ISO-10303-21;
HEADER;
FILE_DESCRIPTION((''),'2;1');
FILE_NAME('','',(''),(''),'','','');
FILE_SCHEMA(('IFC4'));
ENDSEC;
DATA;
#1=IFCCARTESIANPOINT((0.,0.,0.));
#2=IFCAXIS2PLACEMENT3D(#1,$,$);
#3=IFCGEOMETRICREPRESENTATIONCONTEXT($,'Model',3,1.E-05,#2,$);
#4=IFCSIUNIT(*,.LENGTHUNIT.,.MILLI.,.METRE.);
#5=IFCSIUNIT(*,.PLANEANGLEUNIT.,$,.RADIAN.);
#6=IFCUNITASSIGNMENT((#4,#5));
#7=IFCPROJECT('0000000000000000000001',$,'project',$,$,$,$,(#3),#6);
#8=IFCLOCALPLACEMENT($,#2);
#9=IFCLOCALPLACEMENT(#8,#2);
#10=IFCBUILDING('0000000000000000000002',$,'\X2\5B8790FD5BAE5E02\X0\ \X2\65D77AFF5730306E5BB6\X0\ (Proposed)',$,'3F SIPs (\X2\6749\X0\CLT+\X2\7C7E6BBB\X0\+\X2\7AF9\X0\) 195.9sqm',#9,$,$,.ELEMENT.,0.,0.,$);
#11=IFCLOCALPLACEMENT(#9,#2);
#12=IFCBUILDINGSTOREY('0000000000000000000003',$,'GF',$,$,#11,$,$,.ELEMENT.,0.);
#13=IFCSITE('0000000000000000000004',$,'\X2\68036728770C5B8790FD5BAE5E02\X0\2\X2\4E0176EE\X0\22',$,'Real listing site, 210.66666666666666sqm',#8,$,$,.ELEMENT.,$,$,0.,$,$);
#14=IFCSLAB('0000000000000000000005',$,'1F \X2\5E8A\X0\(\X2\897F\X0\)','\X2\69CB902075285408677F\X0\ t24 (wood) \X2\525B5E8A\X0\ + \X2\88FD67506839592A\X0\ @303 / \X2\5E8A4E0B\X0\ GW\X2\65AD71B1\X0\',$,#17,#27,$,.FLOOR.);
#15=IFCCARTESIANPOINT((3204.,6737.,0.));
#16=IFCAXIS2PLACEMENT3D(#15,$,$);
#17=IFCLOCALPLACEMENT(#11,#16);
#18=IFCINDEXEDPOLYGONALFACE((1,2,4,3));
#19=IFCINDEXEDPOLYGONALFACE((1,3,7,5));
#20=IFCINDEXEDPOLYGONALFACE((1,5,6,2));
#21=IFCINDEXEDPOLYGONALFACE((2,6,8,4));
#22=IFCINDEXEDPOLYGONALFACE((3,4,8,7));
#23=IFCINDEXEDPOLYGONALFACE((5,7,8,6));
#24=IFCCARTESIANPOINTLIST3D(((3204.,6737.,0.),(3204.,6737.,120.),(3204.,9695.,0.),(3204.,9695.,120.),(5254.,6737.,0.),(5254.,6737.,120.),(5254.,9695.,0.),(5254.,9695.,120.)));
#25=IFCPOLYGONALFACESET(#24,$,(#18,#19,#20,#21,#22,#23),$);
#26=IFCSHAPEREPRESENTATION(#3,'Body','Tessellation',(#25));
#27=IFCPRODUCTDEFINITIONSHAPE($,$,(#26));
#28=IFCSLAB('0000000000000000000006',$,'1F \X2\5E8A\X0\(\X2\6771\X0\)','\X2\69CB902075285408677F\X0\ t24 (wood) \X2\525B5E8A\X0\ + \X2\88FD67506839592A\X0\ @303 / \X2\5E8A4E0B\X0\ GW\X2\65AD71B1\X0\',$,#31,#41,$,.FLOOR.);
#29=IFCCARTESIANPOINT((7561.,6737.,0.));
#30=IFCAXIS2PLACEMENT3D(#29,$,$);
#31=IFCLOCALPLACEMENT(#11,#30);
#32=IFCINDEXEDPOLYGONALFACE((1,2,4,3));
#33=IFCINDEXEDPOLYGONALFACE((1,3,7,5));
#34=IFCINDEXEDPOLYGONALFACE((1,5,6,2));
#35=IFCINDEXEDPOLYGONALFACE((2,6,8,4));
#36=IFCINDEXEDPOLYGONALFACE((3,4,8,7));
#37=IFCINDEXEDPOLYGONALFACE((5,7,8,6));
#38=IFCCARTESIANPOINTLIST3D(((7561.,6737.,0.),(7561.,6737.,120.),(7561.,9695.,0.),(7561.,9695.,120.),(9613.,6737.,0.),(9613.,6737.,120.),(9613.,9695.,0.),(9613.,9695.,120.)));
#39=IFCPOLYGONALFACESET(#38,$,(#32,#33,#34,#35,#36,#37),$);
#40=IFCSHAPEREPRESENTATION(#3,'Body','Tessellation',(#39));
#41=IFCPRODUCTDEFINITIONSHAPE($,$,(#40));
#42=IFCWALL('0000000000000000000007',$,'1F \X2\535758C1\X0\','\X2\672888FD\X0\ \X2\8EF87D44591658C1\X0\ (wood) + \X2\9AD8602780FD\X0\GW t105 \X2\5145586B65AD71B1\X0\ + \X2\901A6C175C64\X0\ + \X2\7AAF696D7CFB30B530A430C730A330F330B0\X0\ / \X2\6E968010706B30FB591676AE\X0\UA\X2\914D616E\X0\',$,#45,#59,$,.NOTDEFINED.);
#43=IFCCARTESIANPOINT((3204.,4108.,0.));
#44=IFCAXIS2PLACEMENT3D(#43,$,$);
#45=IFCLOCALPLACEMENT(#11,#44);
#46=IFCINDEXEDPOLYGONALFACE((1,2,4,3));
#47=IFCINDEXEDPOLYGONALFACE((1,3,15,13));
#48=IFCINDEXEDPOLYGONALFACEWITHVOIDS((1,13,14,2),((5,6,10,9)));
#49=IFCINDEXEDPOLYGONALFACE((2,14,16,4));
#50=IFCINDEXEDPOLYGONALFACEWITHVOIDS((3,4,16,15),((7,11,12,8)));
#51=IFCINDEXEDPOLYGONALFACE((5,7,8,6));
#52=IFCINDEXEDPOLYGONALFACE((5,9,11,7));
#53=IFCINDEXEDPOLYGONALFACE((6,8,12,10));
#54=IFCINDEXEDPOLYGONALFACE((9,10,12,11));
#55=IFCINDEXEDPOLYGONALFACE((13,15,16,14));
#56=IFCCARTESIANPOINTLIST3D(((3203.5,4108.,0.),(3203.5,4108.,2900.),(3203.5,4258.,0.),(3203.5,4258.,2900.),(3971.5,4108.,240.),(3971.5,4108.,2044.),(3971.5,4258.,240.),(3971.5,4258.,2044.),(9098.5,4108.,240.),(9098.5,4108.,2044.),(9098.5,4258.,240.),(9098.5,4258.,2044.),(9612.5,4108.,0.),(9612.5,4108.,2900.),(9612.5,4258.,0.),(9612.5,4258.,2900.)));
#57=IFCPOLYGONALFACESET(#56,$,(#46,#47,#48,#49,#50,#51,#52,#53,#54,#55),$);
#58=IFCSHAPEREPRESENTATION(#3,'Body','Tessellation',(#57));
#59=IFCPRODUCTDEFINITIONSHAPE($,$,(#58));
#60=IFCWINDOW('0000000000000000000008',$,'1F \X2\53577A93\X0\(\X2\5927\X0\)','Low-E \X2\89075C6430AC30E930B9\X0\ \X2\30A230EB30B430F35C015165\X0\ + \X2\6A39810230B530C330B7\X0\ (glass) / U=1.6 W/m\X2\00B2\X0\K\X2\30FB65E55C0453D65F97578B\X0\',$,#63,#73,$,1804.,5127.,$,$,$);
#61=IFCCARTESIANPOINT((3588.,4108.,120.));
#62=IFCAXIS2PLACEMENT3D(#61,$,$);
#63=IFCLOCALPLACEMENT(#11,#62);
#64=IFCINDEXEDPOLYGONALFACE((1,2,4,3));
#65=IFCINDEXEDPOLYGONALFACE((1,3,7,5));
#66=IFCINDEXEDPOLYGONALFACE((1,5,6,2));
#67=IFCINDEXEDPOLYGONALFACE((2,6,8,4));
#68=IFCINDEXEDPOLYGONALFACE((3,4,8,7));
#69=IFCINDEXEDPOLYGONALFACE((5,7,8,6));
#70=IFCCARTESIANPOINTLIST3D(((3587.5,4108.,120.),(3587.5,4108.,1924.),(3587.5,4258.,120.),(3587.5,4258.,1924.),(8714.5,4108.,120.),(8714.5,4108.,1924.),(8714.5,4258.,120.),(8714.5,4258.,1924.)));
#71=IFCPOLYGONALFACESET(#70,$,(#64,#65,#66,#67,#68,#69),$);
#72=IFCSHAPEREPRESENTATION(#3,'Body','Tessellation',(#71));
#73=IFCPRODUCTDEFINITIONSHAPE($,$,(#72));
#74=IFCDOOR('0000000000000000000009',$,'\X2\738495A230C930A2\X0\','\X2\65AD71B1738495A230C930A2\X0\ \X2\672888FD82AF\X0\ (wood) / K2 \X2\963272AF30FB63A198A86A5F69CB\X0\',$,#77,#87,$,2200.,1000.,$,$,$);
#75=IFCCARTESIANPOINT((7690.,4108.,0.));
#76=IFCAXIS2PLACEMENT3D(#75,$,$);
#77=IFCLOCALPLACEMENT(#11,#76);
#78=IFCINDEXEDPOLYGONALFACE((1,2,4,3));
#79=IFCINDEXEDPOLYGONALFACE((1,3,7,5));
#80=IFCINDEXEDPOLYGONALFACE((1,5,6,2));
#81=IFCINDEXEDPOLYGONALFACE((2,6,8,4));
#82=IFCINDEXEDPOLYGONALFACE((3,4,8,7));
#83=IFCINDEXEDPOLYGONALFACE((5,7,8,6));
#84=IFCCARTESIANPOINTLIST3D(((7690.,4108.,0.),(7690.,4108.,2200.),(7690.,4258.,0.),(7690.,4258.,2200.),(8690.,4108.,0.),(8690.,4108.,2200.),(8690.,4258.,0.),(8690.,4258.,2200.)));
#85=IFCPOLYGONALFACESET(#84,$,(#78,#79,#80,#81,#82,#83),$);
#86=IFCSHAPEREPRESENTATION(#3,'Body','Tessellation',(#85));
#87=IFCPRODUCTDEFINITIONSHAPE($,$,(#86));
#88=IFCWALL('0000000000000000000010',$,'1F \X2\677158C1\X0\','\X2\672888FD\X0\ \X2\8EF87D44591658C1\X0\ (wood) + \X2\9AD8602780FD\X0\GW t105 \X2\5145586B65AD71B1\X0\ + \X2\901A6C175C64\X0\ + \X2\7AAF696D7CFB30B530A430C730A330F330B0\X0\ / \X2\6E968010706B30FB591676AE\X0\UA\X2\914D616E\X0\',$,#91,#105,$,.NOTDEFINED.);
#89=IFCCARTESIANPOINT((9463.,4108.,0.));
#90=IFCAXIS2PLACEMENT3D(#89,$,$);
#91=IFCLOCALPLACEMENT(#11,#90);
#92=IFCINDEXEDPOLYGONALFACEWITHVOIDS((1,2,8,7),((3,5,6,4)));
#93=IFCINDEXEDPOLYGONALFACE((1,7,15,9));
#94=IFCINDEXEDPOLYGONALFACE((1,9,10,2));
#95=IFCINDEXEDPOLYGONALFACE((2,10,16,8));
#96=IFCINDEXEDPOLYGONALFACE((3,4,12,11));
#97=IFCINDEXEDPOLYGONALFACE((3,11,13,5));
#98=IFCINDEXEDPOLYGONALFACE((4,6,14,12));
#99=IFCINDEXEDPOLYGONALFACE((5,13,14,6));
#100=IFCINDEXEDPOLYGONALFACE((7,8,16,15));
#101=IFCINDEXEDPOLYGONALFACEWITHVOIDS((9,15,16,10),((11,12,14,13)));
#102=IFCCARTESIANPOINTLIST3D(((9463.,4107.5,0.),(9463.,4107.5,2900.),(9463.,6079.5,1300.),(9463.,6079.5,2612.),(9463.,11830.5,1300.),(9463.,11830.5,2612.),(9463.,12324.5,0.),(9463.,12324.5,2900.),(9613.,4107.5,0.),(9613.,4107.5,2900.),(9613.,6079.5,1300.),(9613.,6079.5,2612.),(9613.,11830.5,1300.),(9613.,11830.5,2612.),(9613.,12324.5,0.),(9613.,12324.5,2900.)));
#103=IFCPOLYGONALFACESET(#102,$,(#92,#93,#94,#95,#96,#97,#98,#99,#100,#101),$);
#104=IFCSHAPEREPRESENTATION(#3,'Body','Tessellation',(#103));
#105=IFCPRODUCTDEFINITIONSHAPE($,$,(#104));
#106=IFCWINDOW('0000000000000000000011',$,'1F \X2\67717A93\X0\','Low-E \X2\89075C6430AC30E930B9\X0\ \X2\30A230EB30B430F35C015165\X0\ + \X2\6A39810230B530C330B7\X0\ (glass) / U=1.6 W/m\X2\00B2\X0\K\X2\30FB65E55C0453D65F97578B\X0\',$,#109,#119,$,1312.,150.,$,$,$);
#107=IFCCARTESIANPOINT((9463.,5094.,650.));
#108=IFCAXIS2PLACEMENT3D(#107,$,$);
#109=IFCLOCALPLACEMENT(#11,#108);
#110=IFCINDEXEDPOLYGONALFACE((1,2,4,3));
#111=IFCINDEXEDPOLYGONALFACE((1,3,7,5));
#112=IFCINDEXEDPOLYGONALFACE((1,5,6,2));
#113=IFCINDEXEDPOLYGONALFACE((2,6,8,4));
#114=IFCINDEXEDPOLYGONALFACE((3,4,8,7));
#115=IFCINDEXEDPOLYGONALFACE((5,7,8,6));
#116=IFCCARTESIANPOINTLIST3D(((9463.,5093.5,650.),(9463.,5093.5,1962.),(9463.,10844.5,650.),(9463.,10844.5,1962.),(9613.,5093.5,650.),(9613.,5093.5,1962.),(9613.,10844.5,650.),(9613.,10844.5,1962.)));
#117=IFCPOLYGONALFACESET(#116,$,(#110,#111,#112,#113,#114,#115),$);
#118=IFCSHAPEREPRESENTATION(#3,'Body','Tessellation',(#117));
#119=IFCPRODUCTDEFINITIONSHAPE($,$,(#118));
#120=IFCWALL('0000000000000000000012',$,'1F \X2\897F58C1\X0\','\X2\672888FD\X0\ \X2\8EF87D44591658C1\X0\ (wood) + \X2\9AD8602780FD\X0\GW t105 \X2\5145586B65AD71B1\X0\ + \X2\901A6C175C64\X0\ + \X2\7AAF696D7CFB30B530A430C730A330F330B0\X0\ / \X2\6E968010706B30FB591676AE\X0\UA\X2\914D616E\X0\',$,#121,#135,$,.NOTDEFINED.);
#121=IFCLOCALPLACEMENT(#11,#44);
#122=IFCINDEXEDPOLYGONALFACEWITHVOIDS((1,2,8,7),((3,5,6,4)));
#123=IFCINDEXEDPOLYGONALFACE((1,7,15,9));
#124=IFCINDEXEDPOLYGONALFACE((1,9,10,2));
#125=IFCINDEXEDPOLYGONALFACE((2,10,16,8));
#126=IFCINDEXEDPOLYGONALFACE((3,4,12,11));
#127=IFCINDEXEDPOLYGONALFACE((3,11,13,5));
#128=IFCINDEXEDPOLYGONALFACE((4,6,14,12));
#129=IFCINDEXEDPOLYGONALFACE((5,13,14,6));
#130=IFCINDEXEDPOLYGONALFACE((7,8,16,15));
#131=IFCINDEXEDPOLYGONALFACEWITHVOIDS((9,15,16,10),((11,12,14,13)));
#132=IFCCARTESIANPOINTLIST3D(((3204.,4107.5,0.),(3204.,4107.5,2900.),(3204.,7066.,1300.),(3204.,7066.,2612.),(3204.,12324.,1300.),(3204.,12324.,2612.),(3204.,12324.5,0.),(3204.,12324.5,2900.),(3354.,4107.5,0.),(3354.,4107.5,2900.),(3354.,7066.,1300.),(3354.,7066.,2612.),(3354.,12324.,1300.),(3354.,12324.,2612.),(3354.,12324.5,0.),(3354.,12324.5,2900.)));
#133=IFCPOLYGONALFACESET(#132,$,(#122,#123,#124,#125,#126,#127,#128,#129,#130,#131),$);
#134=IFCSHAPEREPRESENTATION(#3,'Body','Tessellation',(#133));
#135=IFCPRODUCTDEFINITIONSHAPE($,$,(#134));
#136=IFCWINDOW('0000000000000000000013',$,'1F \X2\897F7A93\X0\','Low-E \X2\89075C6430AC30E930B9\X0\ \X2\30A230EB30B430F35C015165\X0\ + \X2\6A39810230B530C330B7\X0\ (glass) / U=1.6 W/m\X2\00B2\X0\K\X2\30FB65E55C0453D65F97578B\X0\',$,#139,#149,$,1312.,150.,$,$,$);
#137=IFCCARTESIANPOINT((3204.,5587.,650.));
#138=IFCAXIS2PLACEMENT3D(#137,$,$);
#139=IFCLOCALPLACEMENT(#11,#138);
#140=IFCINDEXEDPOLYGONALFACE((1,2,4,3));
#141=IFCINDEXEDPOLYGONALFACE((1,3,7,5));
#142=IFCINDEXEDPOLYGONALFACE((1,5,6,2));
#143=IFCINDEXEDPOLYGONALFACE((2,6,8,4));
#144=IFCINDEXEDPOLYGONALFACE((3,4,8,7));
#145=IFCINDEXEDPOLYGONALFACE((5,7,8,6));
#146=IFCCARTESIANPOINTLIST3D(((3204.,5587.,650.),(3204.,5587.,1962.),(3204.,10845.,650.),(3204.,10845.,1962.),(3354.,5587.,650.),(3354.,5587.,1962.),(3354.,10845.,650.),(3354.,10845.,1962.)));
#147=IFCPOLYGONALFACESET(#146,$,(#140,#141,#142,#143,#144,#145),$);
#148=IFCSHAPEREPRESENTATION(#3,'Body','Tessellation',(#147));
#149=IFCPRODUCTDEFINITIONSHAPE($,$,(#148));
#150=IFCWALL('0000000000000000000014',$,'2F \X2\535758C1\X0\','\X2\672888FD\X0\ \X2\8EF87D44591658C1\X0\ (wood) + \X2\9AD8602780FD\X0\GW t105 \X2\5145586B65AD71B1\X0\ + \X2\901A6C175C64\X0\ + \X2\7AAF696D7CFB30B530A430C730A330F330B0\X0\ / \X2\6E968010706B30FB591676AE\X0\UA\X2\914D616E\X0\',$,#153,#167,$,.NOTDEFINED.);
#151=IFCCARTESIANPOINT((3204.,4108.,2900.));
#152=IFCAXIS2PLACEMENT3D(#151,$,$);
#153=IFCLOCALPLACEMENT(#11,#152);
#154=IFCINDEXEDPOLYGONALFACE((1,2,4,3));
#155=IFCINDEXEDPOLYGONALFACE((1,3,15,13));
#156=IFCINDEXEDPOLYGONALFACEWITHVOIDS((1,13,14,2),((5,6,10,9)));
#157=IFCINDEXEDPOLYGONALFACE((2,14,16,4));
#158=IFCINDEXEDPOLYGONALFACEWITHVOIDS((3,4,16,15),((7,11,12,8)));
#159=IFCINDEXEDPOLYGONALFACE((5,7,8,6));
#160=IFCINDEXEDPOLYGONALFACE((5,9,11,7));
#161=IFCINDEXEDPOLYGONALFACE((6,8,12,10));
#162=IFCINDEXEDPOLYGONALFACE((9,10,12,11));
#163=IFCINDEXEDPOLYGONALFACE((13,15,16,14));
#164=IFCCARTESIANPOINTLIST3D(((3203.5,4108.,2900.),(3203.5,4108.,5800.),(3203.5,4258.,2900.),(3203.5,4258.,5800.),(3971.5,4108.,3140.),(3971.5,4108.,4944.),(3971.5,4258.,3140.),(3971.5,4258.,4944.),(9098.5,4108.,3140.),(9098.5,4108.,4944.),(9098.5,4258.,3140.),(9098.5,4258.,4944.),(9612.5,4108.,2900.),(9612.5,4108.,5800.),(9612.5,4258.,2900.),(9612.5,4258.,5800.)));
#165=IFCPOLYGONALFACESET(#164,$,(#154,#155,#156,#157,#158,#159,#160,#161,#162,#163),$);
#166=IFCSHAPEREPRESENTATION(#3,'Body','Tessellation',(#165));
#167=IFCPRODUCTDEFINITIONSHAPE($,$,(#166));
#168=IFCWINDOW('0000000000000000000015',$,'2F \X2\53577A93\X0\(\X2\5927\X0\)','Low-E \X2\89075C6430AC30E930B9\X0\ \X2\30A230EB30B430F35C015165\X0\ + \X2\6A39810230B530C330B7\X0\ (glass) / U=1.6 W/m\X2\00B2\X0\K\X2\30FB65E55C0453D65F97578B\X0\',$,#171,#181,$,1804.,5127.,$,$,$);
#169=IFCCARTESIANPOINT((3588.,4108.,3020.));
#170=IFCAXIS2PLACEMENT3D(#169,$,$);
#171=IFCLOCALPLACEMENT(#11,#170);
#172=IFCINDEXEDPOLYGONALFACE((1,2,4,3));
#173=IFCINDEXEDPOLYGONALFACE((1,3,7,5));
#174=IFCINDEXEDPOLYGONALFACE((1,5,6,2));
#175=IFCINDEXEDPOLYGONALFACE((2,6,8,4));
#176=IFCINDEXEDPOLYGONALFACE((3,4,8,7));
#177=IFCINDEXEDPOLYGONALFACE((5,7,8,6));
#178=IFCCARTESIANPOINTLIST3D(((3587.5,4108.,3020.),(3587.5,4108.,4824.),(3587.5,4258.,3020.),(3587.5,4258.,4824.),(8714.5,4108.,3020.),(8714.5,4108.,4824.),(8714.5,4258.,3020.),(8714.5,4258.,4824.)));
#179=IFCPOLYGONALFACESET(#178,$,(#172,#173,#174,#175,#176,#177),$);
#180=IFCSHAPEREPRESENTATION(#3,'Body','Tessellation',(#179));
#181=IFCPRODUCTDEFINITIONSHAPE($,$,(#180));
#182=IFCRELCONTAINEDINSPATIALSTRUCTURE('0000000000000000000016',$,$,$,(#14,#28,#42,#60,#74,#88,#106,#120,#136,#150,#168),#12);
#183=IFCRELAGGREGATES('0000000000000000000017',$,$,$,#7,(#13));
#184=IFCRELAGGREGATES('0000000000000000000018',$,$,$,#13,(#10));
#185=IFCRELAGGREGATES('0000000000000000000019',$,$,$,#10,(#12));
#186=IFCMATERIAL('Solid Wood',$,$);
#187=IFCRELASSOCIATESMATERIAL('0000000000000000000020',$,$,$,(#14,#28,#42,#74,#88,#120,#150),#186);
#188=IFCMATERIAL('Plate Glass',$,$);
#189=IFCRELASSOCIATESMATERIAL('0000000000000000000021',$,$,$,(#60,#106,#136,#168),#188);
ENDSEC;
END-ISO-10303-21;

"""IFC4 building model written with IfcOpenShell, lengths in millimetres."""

from ifc_helpers import new_model, si_unit, frame, frame_2d, origin, place, context, project, spatial, rectangle, extrude, material, element, fill, save


model = new_model("IFC4")

# Units and contexts
model_context = context("Model", 3, precision=1e-05, world=origin())
ifc_project = project(units=[si_unit("LENGTHUNIT", "METRE", prefix="MILLI"), si_unit("PLANEANGLEUNIT", "RADIAN")], contexts=[model_context])

# Site, building, storey
site_placement = place(None, origin())
site = spatial("IfcSite", under=ifc_project, at=site_placement, Name="栃木県宇都宮市2丁目22", ObjectType="Real listing site, 210.66666666666666sqm", CompositionType="ELEMENT", RefElevation=0.0)
building_placement = place(site_placement, origin())
building = spatial("IfcBuilding", under=site, at=building_placement, Name="宇都宮市 旗竿地の家 (Proposed)", ObjectType="3F SIPs (杉CLT+籾殻+竹) 195.9sqm", CompositionType="ELEMENT", ElevationOfRefHeight=0.0, ElevationOfTerrain=0.0)
storey_placement = place(building_placement, origin())
storey = spatial("IfcBuildingStorey", under=building, at=storey_placement, Name="GF", CompositionType="ELEMENT", Elevation=0.0)

# Slabs
ifc_material_1 = material(Name="Solid Wood")
slab_1_placement = place(storey_placement, frame((3204.0, 6737.0, 0.0)))
element("IfcSlab", 1, at=slab_1_placement, inside=storey, material=ifc_material_1, Name="1F 床(西)", Description="構造用合板 t24 (wood) 剛床 + 製材根太 @303 / 床下 GW断熱", PredefinedType="FLOOR", context=model_context, shape_type="SweptSolid", body=[
    extrude(rectangle(XDim=2050.0, YDim=2958.0, at=frame_2d((1025.0, 1479.0))), frame((3204.0, 6737.0, 0.0)), (0.0, 0.0, 1.0), 120.0),
])
slab_2_placement = place(storey_placement, frame((7561.0, 6737.0, 0.0)))
element("IfcSlab", 2, at=slab_2_placement, inside=storey, material=ifc_material_1, Name="1F 床(東)", Description="構造用合板 t24 (wood) 剛床 + 製材根太 @303 / 床下 GW断熱", PredefinedType="FLOOR", context=model_context, shape_type="SweptSolid", body=[
    extrude(rectangle(XDim=2052.0, YDim=2958.0, at=frame_2d((1026.0, 1479.0))), frame((7561.0, 6737.0, 0.0)), (0.0, 0.0, 1.0), 120.0),
])

# Wall, openings, window, door
wall_1_placement = place(storey_placement, frame((3204.0, 4108.0, 0.0)))
wall_1 = element("IfcWall", 3, at=wall_1_placement, inside=storey, material=ifc_material_1, Name="1F 南壁", Description="木製 軸組外壁 (wood) + 高性能GW t105 充填断熱 + 通気層 + 窯業系サイディング / 準耐火・外皮UA配慮", PredefinedType="NOTDEFINED", context=model_context, shape_type="SweptSolid", body=[
    extrude(rectangle(XDim=6409.0, YDim=150.0, at=frame_2d((3204.0, 75.0))), frame((3204.0, 4108.0, 0.0)), (0.0, 0.0, 1.0), 2900.0),
])
opening_1_placement = place(storey_placement, frame((3588.0, 4108.0, 120.0)))
opening_1 = element("IfcOpeningElement", 4, at=opening_1_placement, cuts=wall_1, PredefinedType="NOTDEFINED", context=model_context, shape_type="SweptSolid", body=[
    extrude(rectangle(XDim=5127.0, YDim=150.0, at=frame_2d((2563.0, 75.0))), frame((3588.0, 4108.0, 120.0)), (0.0, 0.0, 1.0), 1804.0),
])
opening_2_placement = place(storey_placement, frame((7690.0, 4108.0, 0.0)))
opening_2 = element("IfcOpeningElement", 5, at=opening_2_placement, cuts=wall_1, PredefinedType="NOTDEFINED", context=model_context, shape_type="SweptSolid", body=[
    extrude(rectangle(XDim=1000.0, YDim=150.0, at=frame_2d((500.0, 75.0))), frame((7690.0, 4108.0, 0.0)), (0.0, 0.0, 1.0), 2200.0),
])
ifc_material_2 = material(Name="Plate Glass")
window_1_placement = place(storey_placement, frame((3588.0, 4108.0, 120.0)))
window_1 = element("IfcWindow", 6, at=window_1_placement, inside=storey, material=ifc_material_2, Name="1F 南窓(大)", Description="Low-E 複層ガラス アルゴン封入 + 樹脂サッシ (glass) / U=1.6 W/m²K・日射取得型", OverallHeight=1804.0, OverallWidth=5127.0, context=model_context, shape_type="SweptSolid", body=[
    extrude(rectangle(XDim=5127.0, YDim=150.0, at=frame_2d((2563.0, 75.0))), frame((3588.0, 4108.0, 120.0)), (0.0, 0.0, 1.0), 1804.0),
])
fill(opening_1, window_1)
door_placement = place(storey_placement, frame((7690.0, 4108.0, 0.0)))
door = element("IfcDoor", 7, at=door_placement, inside=storey, material=ifc_material_1, Name="玄関ドア", Description="断熱玄関ドア 木製芯 (wood) / K2 防犯・採風機構", OverallHeight=2200.0, OverallWidth=1000.0, context=model_context, shape_type="SweptSolid", body=[
    extrude(rectangle(XDim=1000.0, YDim=150.0, at=frame_2d((500.0, 75.0))), frame((7690.0, 4108.0, 0.0)), (0.0, 0.0, 1.0), 2200.0),
])
fill(opening_2, door)

# Walls, openings, windows
wall_2_placement = place(storey_placement, frame((9463.0, 4108.0, 0.0)))
wall_2 = element("IfcWall", 8, at=wall_2_placement, inside=storey, material=ifc_material_1, Name="1F 東壁", Description="木製 軸組外壁 (wood) + 高性能GW t105 充填断熱 + 通気層 + 窯業系サイディング / 準耐火・外皮UA配慮", PredefinedType="NOTDEFINED", context=model_context, shape_type="SweptSolid", body=[
    extrude(rectangle(XDim=150.0, YDim=8217.0, at=frame_2d((75.0, 4108.0))), frame((9463.0, 4108.0, 0.0)), (0.0, 0.0, 1.0), 2900.0),
])
opening_3_placement = place(storey_placement, frame((9463.0, 5094.0, 650.0)))
opening_3 = element("IfcOpeningElement", 9, at=opening_3_placement, cuts=wall_2, PredefinedType="NOTDEFINED", context=model_context, shape_type="SweptSolid", body=[
    extrude(rectangle(XDim=150.0, YDim=5751.0, at=frame_2d((75.0, 2875.0))), frame((9463.0, 5094.0, 650.0)), (0.0, 0.0, 1.0), 1312.0),
])
window_2_placement = place(storey_placement, frame((9463.0, 5094.0, 650.0)))
window_2 = element("IfcWindow", 10, at=window_2_placement, inside=storey, material=ifc_material_2, Name="1F 東窓", Description="Low-E 複層ガラス アルゴン封入 + 樹脂サッシ (glass) / U=1.6 W/m²K・日射取得型", OverallHeight=1312.0, OverallWidth=150.0, context=model_context, shape_type="SweptSolid", body=[
    extrude(rectangle(XDim=150.0, YDim=5751.0, at=frame_2d((75.0, 2875.0))), frame((9463.0, 5094.0, 650.0)), (0.0, 0.0, 1.0), 1312.0),
])
fill(opening_3, window_2)
wall_3_placement = place(storey_placement, frame((3204.0, 4108.0, 0.0)))
wall_3 = element("IfcWall", 11, at=wall_3_placement, inside=storey, material=ifc_material_1, Name="1F 西壁", Description="木製 軸組外壁 (wood) + 高性能GW t105 充填断熱 + 通気層 + 窯業系サイディング / 準耐火・外皮UA配慮", PredefinedType="NOTDEFINED", context=model_context, shape_type="SweptSolid", body=[
    extrude(rectangle(XDim=150.0, YDim=8217.0, at=frame_2d((75.0, 4108.0))), frame((3204.0, 4108.0, 0.0)), (0.0, 0.0, 1.0), 2900.0),
])
opening_4_placement = place(storey_placement, frame((3204.0, 5587.0, 650.0)))
opening_4 = element("IfcOpeningElement", 12, at=opening_4_placement, cuts=wall_3, PredefinedType="NOTDEFINED", context=model_context, shape_type="SweptSolid", body=[
    extrude(rectangle(XDim=150.0, YDim=5258.0, at=frame_2d((75.0, 2629.0))), frame((3204.0, 5587.0, 650.0)), (0.0, 0.0, 1.0), 1312.0),
])
window_3_placement = place(storey_placement, frame((3204.0, 5587.0, 650.0)))
window_3 = element("IfcWindow", 13, at=window_3_placement, inside=storey, material=ifc_material_2, Name="1F 西窓", Description="Low-E 複層ガラス アルゴン封入 + 樹脂サッシ (glass) / U=1.6 W/m²K・日射取得型", OverallHeight=1312.0, OverallWidth=150.0, context=model_context, shape_type="SweptSolid", body=[
    extrude(rectangle(XDim=150.0, YDim=5258.0, at=frame_2d((75.0, 2629.0))), frame((3204.0, 5587.0, 650.0)), (0.0, 0.0, 1.0), 1312.0),
])
fill(opening_4, window_3)
wall_4_placement = place(storey_placement, frame((3204.0, 4108.0, 2900.0)))
wall_4 = element("IfcWall", 14, at=wall_4_placement, inside=storey, material=ifc_material_1, Name="2F 南壁", Description="木製 軸組外壁 (wood) + 高性能GW t105 充填断熱 + 通気層 + 窯業系サイディング / 準耐火・外皮UA配慮", PredefinedType="NOTDEFINED", context=model_context, shape_type="SweptSolid", body=[
    extrude(rectangle(XDim=6409.0, YDim=150.0, at=frame_2d((3204.0, 75.0))), frame((3204.0, 4108.0, 2900.0)), (0.0, 0.0, 1.0), 2900.0),
])
opening_5_placement = place(storey_placement, frame((3588.0, 4108.0, 3020.0)))
opening_5 = element("IfcOpeningElement", 15, at=opening_5_placement, cuts=wall_4, PredefinedType="NOTDEFINED", context=model_context, shape_type="SweptSolid", body=[
    extrude(rectangle(XDim=5127.0, YDim=150.0, at=frame_2d((2563.0, 75.0))), frame((3588.0, 4108.0, 3020.0)), (0.0, 0.0, 1.0), 1804.0),
])
window_4_placement = place(storey_placement, frame((3588.0, 4108.0, 3020.0)))
window_4 = element("IfcWindow", 16, at=window_4_placement, inside=storey, material=ifc_material_2, Name="2F 南窓(大)", Description="Low-E 複層ガラス アルゴン封入 + 樹脂サッシ (glass) / U=1.6 W/m²K・日射取得型", OverallHeight=1804.0, OverallWidth=5127.0, context=model_context, shape_type="SweptSolid", body=[
    extrude(rectangle(XDim=5127.0, YDim=150.0, at=frame_2d((2563.0, 75.0))), frame((3588.0, 4108.0, 3020.0)), (0.0, 0.0, 1.0), 1804.0),
])
fill(opening_5, window_4)

save(model, "model.ifc")
